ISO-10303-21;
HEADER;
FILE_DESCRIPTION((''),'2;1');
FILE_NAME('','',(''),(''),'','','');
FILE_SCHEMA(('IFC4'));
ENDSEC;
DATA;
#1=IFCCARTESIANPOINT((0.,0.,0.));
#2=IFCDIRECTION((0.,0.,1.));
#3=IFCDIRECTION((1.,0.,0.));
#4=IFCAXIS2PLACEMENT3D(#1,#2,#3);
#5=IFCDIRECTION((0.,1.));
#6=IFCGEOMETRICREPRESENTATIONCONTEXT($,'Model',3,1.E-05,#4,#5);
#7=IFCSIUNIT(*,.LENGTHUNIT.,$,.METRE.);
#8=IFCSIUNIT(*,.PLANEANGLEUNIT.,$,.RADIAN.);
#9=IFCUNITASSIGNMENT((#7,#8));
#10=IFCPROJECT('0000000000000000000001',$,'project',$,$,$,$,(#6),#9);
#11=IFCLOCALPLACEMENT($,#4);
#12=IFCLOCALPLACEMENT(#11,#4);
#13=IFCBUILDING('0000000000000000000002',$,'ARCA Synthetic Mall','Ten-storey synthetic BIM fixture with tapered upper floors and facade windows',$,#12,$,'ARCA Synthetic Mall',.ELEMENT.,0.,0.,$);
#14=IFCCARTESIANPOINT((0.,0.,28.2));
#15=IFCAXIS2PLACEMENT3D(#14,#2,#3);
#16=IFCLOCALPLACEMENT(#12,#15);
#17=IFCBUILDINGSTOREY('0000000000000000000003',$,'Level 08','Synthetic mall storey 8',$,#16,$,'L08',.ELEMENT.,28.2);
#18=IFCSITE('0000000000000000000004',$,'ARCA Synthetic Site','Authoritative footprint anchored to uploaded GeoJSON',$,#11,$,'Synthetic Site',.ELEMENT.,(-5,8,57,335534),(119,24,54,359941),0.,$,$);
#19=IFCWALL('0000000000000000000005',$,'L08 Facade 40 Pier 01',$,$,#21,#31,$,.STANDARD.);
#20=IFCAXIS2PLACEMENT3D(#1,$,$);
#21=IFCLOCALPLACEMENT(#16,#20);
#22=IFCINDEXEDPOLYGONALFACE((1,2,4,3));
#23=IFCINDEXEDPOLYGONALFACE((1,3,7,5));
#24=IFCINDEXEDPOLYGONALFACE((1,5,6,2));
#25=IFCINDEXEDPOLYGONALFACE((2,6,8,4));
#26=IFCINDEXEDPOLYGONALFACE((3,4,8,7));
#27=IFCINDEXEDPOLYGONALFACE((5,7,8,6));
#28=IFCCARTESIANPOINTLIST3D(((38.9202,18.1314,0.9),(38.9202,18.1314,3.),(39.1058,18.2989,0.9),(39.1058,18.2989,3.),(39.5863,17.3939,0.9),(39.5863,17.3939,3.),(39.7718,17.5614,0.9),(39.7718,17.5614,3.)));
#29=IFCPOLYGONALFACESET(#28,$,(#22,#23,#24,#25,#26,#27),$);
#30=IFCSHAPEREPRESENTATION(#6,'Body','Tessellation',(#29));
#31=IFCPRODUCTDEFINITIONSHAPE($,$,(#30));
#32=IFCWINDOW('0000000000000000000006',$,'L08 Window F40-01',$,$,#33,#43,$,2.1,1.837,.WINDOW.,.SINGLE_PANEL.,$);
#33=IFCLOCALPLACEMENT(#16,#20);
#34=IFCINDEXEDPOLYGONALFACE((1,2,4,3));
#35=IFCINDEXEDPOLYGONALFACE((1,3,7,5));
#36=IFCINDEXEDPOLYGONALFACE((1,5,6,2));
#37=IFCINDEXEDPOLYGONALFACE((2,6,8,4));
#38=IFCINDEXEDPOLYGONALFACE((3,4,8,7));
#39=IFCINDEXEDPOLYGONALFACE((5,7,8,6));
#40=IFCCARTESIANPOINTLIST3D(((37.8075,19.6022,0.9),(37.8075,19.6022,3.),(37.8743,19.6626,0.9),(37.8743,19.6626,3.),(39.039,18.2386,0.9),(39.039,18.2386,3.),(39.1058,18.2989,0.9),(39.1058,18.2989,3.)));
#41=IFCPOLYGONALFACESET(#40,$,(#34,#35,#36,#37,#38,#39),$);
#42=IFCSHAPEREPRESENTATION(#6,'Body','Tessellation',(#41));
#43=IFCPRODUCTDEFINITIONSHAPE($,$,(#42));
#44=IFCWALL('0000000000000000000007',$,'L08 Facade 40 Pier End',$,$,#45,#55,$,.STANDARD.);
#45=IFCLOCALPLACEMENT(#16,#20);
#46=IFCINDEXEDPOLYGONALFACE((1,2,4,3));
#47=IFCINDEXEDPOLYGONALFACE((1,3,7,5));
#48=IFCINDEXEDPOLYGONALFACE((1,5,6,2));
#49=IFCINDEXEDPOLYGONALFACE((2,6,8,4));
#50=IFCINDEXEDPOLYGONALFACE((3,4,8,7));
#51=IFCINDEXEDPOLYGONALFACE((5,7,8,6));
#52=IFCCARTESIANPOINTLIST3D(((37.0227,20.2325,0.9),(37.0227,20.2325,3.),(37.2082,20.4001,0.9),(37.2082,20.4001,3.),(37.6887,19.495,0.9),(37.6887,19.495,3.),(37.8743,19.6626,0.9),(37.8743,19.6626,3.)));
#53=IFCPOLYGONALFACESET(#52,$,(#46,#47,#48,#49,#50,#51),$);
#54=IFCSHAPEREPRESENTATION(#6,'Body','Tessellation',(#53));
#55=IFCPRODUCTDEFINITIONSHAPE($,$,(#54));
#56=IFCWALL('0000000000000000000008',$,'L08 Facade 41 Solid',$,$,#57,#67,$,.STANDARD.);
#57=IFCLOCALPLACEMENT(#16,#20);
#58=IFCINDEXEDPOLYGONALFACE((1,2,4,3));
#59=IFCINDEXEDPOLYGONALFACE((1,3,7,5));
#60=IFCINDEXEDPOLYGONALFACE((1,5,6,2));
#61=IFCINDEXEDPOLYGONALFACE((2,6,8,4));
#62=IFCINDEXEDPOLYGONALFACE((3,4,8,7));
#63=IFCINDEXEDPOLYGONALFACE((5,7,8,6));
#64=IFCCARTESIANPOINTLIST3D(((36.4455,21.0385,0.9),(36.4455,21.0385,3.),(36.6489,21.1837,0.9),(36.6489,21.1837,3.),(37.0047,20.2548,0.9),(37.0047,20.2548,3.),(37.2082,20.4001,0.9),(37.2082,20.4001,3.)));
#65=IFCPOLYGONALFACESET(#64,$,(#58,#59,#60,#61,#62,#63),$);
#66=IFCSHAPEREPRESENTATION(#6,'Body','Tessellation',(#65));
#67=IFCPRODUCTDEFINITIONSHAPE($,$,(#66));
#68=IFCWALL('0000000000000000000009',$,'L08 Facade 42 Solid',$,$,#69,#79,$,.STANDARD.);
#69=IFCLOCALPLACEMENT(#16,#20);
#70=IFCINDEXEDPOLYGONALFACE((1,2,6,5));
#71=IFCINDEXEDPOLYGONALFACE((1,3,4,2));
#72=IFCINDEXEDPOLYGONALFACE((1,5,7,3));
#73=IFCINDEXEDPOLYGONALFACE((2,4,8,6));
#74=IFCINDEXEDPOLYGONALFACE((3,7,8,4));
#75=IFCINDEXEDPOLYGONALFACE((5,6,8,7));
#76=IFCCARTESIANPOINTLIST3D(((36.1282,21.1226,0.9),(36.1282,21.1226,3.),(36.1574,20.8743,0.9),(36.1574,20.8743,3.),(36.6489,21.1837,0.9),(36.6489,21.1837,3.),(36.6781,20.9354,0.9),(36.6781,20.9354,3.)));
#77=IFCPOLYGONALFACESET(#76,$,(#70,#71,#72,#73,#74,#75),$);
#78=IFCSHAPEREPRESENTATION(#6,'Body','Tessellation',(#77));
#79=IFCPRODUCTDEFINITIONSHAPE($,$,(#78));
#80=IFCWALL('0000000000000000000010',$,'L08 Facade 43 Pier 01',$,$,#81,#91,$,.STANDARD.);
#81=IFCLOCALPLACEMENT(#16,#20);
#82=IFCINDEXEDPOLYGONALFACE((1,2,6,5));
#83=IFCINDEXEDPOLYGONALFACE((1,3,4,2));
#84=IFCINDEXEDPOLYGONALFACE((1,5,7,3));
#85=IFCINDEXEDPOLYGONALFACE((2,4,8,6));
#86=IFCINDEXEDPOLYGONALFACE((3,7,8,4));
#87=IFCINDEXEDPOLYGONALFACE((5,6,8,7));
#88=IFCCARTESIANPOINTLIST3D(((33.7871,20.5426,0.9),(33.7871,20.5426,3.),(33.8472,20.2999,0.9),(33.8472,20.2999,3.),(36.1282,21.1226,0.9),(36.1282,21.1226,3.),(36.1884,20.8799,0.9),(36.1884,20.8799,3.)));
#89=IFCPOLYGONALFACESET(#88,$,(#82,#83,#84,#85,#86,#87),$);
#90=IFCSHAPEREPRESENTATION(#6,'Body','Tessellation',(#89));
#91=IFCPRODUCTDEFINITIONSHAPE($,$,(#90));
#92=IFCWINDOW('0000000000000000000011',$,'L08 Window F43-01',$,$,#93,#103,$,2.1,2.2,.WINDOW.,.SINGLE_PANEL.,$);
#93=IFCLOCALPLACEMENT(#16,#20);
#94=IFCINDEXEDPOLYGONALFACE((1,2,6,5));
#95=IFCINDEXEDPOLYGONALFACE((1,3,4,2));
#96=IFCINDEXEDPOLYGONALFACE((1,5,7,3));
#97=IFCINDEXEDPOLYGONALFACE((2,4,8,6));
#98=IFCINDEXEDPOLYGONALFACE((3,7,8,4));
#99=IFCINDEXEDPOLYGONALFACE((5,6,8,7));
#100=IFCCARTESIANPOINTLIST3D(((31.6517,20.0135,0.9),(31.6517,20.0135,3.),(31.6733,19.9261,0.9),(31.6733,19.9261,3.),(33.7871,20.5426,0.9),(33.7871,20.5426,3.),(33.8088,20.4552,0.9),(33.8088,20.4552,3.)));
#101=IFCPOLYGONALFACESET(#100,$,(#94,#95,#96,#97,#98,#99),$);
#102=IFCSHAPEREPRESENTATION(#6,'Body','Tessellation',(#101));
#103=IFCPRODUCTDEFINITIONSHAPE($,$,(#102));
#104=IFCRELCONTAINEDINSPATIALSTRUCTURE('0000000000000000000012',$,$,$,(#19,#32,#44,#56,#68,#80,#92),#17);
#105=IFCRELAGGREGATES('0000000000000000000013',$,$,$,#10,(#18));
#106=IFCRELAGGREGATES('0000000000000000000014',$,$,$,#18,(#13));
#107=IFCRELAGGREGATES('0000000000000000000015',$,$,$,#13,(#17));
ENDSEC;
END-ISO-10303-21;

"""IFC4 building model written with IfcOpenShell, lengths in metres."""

from ifc_helpers import new_model, si_unit, direction, frame, origin_with_axes, place, context, project, spatial, polyline, outline, extrude, element, save


model = new_model("IFC4")

# Units and contexts
model_context = context("Model", 3, precision=1e-05, world=origin_with_axes(), true_north=direction((0.0, 1.0)))
ifc_project = project(units=[si_unit("LENGTHUNIT", "METRE"), si_unit("PLANEANGLEUNIT", "RADIAN")], contexts=[model_context])

# Site, building, storey
site_placement = place(None, origin_with_axes())
site = spatial("IfcSite", under=ifc_project, at=site_placement, Name="ARCA Synthetic Site", Description="Authoritative footprint anchored to uploaded GeoJSON", LongName="Synthetic Site", CompositionType="ELEMENT", RefLatitude=(-5, 8, 57, 335534), RefLongitude=(119, 24, 54, 359941), RefElevation=0.0)
building_placement = place(site_placement, origin_with_axes())
building = spatial("IfcBuilding", under=site, at=building_placement, Name="ARCA Synthetic Mall", Description="Ten-storey synthetic BIM fixture with tapered upper floors and facade windows", LongName="ARCA Synthetic Mall", CompositionType="ELEMENT", ElevationOfRefHeight=0.0, ElevationOfTerrain=0.0)
storey_placement = place(building_placement, frame((0.0, 0.0, 28.2), z_axis=(0.0, 0.0, 1.0), x_axis=(1.0, 0.0, 0.0)))
storey = spatial("IfcBuildingStorey", under=building, at=storey_placement, Name="Level 08", Description="Synthetic mall storey 8", LongName="L08", CompositionType="ELEMENT", Elevation=28.2)

# Wall
wall_1_placement = place(storey_placement, frame((0.0, 0.0, 0.9), z_axis=(0.0, 0.0, 1.0), x_axis=(1.0, 0.0, 0.0)))
element("IfcWall", 1, at=wall_1_placement, inside=storey, Name="L08 Facade 40 Pier 01", PredefinedType="STANDARD", context=model_context, shape_type="SweptSolid", body=[
    extrude(outline(polyline([(39.7718, 17.5614), (39.1058, 18.2989), (38.9202, 18.1314), (39.5863, 17.3939), (39.7718, 17.5614)])), origin_with_axes(), (0.0, 0.0, 1.0), 2.1),
])

# Window
window_1_placement = place(storey_placement, frame((0.0, 0.0, 0.9), z_axis=(0.0, 0.0, 1.0), x_axis=(1.0, 0.0, 0.0)))
element("IfcWindow", 2, at=window_1_placement, inside=storey, Name="L08 Window F40-01", OverallHeight=2.1, OverallWidth=1.837, PartitioningType="SINGLE_PANEL", PredefinedType="WINDOW", context=model_context, shape_type="SweptSolid", body=[
    extrude(outline(polyline([(39.1058, 18.2989), (37.8743, 19.6626), (37.8075, 19.6022), (39.039, 18.2386), (39.1058, 18.2989)])), origin_with_axes(), (0.0, 0.0, 1.0), 2.1),
])

# Walls
wall_2_placement = place(storey_placement, frame((0.0, 0.0, 0.9), z_axis=(0.0, 0.0, 1.0), x_axis=(1.0, 0.0, 0.0)))
element("IfcWall", 3, at=wall_2_placement, inside=storey, Name="L08 Facade 40 Pier End", PredefinedType="STANDARD", context=model_context, shape_type="SweptSolid", body=[
    extrude(outline(polyline([(37.8743, 19.6626), (37.2082, 20.4001), (37.0227, 20.2325), (37.6887, 19.495), (37.8743, 19.6626)])), origin_with_axes(), (0.0, 0.0, 1.0), 2.1),
])
wall_3_placement = place(storey_placement, frame((0.0, 0.0, 0.9), z_axis=(0.0, 0.0, 1.0), x_axis=(1.0, 0.0, 0.0)))
element("IfcWall", 4, at=wall_3_placement, inside=storey, Name="L08 Facade 41 Solid", PredefinedType="STANDARD", context=model_context, shape_type="SweptSolid", body=[
    extrude(outline(polyline([(37.2082, 20.4001), (36.6489, 21.1837), (36.4455, 21.0385), (37.0047, 20.2548), (37.2082, 20.4001)])), origin_with_axes(), (0.0, 0.0, 1.0), 2.1),
])
wall_4_placement = place(storey_placement, frame((0.0, 0.0, 0.9), z_axis=(0.0, 0.0, 1.0), x_axis=(1.0, 0.0, 0.0)))
element("IfcWall", 5, at=wall_4_placement, inside=storey, Name="L08 Facade 42 Solid", PredefinedType="STANDARD", context=model_context, shape_type="SweptSolid", body=[
    extrude(outline(polyline([(36.6489, 21.1837), (36.1283, 21.1226), (36.1574, 20.8743), (36.6781, 20.9354), (36.6489, 21.1837)])), origin_with_axes(), (0.0, 0.0, 1.0), 2.1),
])
wall_5_placement = place(storey_placement, frame((0.0, 0.0, 0.9), z_axis=(0.0, 0.0, 1.0), x_axis=(1.0, 0.0, 0.0)))
element("IfcWall", 6, at=wall_5_placement, inside=storey, Name="L08 Facade 43 Pier 01", PredefinedType="STANDARD", context=model_context, shape_type="SweptSolid", body=[
    extrude(outline(polyline([(36.1283, 21.1226), (33.7871, 20.5426), (33.8472, 20.2999), (36.1884, 20.8799), (36.1283, 21.1226)])), origin_with_axes(), (0.0, 0.0, 1.0), 2.1),
])

# Window
window_2_placement = place(storey_placement, frame((0.0, 0.0, 0.9), z_axis=(0.0, 0.0, 1.0), x_axis=(1.0, 0.0, 0.0)))
element("IfcWindow", 7, at=window_2_placement, inside=storey, Name="L08 Window F43-01", OverallHeight=2.1, OverallWidth=2.2, PartitioningType="SINGLE_PANEL", PredefinedType="WINDOW", context=model_context, shape_type="SweptSolid", body=[
    extrude(outline(polyline([(33.7871, 20.5426), (31.6517, 20.0135), (31.6733, 19.9261), (33.8088, 20.4552), (33.7871, 20.5426)])), origin_with_axes(), (0.0, 0.0, 1.0), 2.1),
])

save(model, "model.ifc")
